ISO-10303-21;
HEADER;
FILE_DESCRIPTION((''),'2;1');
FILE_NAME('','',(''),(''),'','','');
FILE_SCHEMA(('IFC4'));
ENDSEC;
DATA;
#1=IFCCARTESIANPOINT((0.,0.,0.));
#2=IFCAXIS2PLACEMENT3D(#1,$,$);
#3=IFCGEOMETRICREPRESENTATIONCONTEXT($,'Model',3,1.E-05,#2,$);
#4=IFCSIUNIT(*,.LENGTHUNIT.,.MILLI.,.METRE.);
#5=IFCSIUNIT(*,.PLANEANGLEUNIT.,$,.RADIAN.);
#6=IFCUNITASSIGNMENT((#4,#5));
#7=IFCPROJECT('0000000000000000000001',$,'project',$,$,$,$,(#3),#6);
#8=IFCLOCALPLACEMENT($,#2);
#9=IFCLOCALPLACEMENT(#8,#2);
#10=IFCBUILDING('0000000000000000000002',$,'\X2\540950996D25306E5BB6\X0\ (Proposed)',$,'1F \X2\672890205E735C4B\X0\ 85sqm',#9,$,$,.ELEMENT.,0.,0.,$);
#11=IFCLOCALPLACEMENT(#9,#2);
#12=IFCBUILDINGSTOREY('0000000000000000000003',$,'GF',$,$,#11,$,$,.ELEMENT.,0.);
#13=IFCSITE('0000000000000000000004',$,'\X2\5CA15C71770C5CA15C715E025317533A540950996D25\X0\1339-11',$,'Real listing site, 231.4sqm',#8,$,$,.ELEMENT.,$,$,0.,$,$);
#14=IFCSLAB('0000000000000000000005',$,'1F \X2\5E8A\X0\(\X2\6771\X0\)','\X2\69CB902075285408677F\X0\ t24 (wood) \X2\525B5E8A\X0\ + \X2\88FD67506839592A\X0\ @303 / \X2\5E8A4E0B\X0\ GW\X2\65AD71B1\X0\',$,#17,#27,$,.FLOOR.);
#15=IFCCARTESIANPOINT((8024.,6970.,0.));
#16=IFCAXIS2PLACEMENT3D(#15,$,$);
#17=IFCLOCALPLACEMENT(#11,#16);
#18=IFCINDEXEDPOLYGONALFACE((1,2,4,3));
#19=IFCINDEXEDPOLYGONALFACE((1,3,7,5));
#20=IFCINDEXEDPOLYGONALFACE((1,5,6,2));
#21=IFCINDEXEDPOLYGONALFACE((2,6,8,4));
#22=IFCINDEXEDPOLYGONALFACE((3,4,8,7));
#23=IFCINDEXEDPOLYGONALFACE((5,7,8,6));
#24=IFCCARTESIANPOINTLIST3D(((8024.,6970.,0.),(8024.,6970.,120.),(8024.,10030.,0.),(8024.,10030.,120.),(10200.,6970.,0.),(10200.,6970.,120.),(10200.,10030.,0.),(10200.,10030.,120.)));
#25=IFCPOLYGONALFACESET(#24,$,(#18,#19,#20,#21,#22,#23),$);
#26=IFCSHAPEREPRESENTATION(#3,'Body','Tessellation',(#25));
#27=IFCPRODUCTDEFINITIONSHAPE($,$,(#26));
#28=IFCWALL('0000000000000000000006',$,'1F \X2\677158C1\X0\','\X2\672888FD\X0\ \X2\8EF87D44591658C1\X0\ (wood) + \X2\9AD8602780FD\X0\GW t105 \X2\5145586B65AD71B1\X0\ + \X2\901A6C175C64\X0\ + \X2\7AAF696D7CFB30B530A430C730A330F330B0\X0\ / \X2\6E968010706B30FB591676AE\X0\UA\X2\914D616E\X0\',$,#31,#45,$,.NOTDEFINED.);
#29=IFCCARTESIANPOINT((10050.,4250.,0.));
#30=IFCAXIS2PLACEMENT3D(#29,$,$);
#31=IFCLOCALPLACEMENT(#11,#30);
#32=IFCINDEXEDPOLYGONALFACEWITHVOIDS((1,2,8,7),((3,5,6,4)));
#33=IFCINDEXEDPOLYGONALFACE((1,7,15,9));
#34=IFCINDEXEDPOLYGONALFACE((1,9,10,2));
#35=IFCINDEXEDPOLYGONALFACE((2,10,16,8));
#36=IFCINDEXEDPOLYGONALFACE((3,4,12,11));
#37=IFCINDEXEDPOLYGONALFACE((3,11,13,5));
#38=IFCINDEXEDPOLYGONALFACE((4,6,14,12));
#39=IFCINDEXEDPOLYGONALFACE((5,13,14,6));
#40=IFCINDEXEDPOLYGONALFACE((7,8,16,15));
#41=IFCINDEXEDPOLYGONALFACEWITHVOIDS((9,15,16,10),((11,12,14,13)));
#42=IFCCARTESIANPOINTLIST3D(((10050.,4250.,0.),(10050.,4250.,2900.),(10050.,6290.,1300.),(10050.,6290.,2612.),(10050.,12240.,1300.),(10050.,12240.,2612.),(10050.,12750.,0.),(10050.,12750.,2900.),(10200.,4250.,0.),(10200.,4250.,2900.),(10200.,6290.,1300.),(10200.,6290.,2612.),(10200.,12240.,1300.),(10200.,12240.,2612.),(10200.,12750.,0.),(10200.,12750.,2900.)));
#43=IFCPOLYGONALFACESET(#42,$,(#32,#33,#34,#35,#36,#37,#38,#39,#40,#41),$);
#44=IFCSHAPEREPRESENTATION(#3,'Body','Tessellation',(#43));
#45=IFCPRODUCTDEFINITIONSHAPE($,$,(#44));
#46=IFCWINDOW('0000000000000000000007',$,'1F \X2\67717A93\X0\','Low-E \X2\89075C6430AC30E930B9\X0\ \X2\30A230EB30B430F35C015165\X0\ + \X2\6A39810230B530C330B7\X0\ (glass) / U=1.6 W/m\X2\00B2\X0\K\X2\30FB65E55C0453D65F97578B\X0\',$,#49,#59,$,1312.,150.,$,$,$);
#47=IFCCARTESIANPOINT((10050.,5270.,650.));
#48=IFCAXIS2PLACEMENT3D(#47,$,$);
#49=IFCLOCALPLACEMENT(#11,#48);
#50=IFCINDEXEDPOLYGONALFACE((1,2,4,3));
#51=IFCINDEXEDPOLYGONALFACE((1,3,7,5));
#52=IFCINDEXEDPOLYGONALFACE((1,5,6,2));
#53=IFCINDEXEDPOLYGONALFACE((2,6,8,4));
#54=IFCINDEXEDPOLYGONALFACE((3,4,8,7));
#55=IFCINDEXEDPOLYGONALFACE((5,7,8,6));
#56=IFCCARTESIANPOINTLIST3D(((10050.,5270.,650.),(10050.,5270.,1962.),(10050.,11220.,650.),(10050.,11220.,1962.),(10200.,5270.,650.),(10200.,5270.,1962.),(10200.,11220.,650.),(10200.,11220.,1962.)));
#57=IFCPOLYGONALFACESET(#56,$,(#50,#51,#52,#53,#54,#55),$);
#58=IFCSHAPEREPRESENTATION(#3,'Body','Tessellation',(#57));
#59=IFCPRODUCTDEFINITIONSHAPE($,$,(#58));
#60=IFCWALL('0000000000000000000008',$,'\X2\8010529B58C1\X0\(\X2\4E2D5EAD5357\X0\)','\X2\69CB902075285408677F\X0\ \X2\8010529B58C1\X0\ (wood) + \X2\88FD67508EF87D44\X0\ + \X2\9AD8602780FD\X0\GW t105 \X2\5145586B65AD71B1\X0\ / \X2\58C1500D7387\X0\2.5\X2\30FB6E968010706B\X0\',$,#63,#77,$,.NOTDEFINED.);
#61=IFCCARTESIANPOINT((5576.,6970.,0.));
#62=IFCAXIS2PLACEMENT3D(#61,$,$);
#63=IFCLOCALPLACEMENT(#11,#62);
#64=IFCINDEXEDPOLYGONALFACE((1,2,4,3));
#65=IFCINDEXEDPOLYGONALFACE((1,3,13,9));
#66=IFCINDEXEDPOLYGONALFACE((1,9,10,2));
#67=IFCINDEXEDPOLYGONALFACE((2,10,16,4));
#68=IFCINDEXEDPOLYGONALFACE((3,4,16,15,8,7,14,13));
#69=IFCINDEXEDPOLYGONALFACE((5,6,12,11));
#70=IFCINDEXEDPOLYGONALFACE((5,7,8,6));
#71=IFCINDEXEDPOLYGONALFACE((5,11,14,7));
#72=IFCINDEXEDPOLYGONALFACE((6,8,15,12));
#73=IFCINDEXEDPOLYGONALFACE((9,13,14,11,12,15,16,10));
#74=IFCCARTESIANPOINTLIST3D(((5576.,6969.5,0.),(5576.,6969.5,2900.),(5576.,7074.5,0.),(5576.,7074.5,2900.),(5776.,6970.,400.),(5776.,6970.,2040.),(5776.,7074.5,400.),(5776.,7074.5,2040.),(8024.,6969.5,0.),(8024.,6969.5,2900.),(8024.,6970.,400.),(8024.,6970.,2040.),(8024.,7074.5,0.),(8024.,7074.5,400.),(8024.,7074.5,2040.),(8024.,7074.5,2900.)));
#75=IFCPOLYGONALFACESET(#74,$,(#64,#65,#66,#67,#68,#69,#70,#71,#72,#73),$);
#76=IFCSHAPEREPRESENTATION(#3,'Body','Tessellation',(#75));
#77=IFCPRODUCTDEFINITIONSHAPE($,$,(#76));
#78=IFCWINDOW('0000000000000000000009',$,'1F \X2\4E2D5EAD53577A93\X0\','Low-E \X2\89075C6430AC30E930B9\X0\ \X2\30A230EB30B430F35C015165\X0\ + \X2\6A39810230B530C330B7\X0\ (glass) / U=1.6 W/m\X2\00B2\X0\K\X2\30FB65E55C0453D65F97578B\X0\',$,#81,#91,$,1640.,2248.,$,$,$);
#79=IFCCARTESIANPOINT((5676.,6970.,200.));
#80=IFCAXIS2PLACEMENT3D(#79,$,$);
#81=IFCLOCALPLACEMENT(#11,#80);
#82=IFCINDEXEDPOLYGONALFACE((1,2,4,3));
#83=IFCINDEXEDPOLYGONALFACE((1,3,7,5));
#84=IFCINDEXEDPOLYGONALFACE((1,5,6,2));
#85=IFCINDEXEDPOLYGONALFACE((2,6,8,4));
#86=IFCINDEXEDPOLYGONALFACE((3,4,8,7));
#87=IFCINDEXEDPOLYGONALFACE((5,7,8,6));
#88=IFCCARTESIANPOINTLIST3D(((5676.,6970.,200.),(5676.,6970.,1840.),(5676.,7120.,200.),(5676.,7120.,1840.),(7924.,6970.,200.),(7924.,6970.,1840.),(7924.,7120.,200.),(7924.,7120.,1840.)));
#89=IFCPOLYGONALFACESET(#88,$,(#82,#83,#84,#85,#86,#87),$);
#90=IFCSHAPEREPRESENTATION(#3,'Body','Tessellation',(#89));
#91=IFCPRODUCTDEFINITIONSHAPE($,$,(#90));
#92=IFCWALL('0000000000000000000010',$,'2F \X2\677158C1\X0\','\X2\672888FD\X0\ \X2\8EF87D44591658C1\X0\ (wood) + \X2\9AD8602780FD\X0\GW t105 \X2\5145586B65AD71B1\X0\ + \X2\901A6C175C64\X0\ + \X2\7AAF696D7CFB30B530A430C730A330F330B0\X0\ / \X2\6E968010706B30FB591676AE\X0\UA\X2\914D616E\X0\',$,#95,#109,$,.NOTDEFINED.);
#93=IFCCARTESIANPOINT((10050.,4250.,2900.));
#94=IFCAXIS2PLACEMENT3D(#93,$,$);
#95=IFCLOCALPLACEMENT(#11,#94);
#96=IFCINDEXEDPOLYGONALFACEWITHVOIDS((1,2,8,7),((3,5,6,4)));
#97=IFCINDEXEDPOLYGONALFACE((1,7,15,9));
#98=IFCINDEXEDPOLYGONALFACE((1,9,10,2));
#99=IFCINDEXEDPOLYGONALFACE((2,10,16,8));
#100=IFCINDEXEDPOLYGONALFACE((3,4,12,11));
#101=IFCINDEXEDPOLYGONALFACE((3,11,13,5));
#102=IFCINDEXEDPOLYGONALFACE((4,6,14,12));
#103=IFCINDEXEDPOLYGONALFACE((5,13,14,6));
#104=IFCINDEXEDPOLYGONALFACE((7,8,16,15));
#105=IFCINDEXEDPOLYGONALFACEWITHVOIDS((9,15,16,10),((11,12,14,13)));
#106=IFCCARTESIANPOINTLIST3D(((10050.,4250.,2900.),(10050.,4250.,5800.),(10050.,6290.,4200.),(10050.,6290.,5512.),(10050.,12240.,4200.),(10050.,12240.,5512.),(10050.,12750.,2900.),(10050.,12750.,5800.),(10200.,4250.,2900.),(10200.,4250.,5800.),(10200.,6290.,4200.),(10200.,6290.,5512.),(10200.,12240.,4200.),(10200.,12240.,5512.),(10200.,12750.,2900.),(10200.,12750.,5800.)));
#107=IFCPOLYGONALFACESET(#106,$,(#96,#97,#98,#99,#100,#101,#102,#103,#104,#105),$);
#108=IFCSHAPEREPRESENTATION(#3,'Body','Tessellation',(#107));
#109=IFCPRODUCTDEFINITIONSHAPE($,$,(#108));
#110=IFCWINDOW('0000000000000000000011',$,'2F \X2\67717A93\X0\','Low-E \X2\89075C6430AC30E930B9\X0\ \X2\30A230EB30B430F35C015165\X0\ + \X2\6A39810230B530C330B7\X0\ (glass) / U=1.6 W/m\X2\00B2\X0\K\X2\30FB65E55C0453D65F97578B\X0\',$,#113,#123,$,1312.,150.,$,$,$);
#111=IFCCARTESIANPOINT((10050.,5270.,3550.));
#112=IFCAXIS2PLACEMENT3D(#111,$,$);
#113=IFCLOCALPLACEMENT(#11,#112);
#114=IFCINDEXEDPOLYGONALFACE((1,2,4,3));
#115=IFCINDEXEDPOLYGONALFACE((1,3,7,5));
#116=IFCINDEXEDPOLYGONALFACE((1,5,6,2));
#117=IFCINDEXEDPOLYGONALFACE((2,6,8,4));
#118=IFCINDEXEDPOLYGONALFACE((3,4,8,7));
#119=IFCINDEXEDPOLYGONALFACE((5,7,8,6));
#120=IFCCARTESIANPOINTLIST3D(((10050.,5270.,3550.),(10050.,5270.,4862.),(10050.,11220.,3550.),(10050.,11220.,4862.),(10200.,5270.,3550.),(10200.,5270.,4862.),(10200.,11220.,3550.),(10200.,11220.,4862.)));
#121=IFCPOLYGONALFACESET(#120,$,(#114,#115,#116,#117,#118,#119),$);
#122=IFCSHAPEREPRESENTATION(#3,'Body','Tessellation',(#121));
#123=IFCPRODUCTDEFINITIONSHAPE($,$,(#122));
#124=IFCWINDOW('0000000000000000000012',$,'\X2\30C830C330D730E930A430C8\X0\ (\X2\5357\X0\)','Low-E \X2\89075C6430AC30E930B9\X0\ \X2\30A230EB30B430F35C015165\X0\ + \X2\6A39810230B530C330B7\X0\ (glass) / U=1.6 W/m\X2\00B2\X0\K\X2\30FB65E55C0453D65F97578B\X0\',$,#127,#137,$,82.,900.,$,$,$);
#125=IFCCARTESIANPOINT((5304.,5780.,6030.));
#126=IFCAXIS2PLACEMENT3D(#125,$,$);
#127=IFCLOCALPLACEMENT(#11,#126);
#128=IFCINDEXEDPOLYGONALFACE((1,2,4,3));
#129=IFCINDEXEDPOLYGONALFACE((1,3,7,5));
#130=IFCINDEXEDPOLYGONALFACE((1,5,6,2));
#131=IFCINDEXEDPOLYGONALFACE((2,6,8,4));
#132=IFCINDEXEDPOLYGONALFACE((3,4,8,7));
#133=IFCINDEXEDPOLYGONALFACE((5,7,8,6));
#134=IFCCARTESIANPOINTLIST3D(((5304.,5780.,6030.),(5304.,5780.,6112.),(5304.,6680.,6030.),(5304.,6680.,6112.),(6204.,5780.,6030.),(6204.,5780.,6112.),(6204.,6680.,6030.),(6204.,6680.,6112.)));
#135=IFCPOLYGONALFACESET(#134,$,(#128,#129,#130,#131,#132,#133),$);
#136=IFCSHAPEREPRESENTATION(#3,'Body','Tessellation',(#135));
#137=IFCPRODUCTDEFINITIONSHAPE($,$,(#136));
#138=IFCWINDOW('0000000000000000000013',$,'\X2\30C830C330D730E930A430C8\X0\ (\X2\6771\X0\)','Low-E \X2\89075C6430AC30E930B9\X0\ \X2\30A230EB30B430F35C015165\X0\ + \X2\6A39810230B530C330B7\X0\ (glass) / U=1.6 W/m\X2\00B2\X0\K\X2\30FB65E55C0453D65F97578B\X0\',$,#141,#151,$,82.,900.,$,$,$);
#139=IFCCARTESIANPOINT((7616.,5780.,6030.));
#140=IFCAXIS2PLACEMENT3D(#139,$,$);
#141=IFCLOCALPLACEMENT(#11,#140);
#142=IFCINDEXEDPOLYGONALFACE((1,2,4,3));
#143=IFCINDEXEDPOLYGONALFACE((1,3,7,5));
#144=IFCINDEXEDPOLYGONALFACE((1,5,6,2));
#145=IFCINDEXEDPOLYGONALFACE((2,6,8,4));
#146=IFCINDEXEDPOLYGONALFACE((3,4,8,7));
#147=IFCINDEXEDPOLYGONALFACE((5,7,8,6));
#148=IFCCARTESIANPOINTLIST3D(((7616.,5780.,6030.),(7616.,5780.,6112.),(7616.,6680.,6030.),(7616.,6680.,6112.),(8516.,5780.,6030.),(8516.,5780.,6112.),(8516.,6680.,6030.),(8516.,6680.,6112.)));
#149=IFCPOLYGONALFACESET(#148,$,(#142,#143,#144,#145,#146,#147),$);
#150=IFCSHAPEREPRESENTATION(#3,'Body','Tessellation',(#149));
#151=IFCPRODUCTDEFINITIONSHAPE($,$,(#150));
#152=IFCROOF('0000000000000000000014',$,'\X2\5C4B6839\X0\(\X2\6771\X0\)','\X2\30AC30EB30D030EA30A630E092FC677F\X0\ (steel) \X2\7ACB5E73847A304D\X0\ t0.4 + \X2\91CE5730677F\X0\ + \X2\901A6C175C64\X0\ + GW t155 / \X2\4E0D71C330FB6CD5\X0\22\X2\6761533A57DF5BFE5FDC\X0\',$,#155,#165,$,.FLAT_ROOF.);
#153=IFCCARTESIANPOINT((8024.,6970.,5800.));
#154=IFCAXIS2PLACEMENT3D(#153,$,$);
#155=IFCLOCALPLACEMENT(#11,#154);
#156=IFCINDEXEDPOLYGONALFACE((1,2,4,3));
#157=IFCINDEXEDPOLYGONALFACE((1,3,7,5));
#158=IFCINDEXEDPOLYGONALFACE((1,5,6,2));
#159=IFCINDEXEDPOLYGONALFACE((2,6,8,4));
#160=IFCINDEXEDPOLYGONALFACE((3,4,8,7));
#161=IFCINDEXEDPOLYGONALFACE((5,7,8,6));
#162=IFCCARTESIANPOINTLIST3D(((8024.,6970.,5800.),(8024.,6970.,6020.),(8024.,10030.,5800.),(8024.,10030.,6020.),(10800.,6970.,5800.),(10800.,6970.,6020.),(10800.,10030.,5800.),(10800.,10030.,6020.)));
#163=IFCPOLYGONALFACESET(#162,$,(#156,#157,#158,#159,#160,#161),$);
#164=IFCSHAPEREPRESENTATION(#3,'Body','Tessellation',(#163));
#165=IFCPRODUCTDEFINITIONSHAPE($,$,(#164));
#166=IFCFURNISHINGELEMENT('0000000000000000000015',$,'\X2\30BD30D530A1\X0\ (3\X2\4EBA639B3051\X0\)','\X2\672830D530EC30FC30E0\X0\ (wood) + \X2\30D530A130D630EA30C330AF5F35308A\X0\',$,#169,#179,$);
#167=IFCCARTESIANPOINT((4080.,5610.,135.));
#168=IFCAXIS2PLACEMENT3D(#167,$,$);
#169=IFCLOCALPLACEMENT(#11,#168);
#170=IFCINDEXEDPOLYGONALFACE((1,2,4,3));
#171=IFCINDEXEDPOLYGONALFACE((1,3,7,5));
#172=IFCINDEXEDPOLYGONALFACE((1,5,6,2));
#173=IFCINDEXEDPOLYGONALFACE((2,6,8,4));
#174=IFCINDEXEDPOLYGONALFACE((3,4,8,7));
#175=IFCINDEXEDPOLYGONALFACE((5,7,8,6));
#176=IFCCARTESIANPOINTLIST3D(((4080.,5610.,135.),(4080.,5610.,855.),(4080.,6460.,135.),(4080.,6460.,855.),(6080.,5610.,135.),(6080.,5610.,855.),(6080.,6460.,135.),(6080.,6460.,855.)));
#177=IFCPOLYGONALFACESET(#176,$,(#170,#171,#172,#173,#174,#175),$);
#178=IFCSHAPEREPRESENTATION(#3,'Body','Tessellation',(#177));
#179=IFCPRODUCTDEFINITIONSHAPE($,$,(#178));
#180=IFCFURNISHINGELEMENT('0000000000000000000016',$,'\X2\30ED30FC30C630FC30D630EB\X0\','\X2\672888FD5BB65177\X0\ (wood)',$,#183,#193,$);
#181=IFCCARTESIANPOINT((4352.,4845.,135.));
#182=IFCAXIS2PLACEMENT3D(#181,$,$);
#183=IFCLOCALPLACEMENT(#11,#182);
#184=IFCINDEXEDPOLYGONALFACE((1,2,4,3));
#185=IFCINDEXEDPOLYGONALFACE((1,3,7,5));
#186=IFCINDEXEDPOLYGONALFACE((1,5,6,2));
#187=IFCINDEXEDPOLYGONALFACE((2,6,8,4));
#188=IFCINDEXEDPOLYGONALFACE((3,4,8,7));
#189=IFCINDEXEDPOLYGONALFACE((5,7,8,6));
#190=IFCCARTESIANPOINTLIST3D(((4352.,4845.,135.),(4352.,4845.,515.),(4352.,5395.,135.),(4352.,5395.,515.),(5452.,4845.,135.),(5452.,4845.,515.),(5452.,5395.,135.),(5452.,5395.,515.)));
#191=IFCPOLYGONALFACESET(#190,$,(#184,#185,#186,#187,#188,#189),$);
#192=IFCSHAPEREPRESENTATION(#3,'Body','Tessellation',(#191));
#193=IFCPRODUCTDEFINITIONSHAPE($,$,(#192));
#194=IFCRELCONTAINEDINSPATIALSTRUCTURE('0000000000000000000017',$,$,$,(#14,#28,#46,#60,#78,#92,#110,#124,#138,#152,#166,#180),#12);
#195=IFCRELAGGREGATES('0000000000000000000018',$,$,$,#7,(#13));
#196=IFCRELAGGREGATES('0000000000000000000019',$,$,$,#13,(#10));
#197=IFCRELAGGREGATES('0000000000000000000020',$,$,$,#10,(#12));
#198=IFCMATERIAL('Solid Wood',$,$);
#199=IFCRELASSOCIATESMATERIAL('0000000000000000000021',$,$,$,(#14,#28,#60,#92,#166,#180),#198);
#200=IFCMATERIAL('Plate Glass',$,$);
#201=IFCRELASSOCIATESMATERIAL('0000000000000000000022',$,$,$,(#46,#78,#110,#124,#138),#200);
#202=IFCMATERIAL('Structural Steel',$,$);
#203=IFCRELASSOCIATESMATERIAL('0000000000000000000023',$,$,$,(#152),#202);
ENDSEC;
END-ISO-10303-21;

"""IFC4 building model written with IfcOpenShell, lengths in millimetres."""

from ifc_helpers import new_model, si_unit, frame, frame_2d, origin, place, context, project, spatial, rectangle, extrude, material, element, fill, save


model = new_model("IFC4")

# Units and contexts
model_context = context("Model", 3, precision=1e-05, world=origin())
ifc_project = project(units=[si_unit("LENGTHUNIT", "METRE", prefix="MILLI"), si_unit("PLANEANGLEUNIT", "RADIAN")], contexts=[model_context])

# Site, building, storey
site_placement = place(None, origin())
site = spatial("IfcSite", under=ifc_project, at=site_placement, Name="岡山県岡山市北区吉備津1339-11", ObjectType="Real listing site, 231.4sqm", CompositionType="ELEMENT", RefElevation=0.0)
building_placement = place(site_placement, origin())
building = spatial("IfcBuilding", under=site, at=building_placement, Name="吉備津の家 (Proposed)", ObjectType="1F 木造平屋 85sqm", CompositionType="ELEMENT", ElevationOfRefHeight=0.0, ElevationOfTerrain=0.0)
storey_placement = place(building_placement, origin())
storey = spatial("IfcBuildingStorey", under=building, at=storey_placement, Name="GF", CompositionType="ELEMENT", Elevation=0.0)

# Slab
ifc_material_1 = material(Name="Solid Wood")
slab_placement = place(storey_placement, frame((8024.0, 6970.0, 0.0)))
element("IfcSlab", 1, at=slab_placement, inside=storey, material=ifc_material_1, Name="1F 床(東)", Description="構造用合板 t24 (wood) 剛床 + 製材根太 @303 / 床下 GW断熱", PredefinedType="FLOOR", context=model_context, shape_type="SweptSolid", body=[
    extrude(rectangle(XDim=2176.0, YDim=3060.0, at=frame_2d((1088.0, 1530.0))), frame((8024.0, 6970.0, 0.0)), (0.0, 0.0, 1.0), 120.0),
])

# Walls, openings, windows
wall_1_placement = place(storey_placement, frame((10050.0, 4250.0, 0.0)))
wall_1 = element("IfcWall", 2, at=wall_1_placement, inside=storey, material=ifc_material_1, Name="1F 東壁", Description="木製 軸組外壁 (wood) + 高性能GW t105 充填断熱 + 通気層 + 窯業系サイディング / 準耐火・外皮UA配慮", PredefinedType="NOTDEFINED", context=model_context, shape_type="SweptSolid", body=[
    extrude(rectangle(XDim=150.0, YDim=8500.0, at=frame_2d((75.0, 4250.0))), frame((10050.0, 4250.0, 0.0)), (0.0, 0.0, 1.0), 2900.0),
])
opening_1_placement = place(storey_placement, frame((10050.0, 5270.0, 650.0)))
opening_1 = element("IfcOpeningElement", 3, at=opening_1_placement, cuts=wall_1, PredefinedType="NOTDEFINED", context=model_context, shape_type="SweptSolid", body=[
    extrude(rectangle(XDim=150.0, YDim=5950.0, at=frame_2d((75.0, 2975.0))), frame((10050.0, 5270.0, 650.0)), (0.0, 0.0, 1.0), 1312.0),
])
ifc_material_2 = material(Name="Plate Glass")
window_1_placement = place(storey_placement, frame((10050.0, 5270.0, 650.0)))
window_1 = element("IfcWindow", 4, at=window_1_placement, inside=storey, material=ifc_material_2, Name="1F 東窓", Description="Low-E 複層ガラス アルゴン封入 + 樹脂サッシ (glass) / U=1.6 W/m²K・日射取得型", OverallHeight=1312.0, OverallWidth=150.0, context=model_context, shape_type="SweptSolid", body=[
    extrude(rectangle(XDim=150.0, YDim=5950.0, at=frame_2d((75.0, 2975.0))), frame((10050.0, 5270.0, 650.0)), (0.0, 0.0, 1.0), 1312.0),
])
fill(opening_1, window_1)
wall_2_placement = place(storey_placement, frame((5576.0, 6970.0, 0.0)))
wall_2 = element("IfcWall", 5, at=wall_2_placement, inside=storey, material=ifc_material_1, Name="耐力壁(中庭南)", Description="構造用合板 耐力壁 (wood) + 製材軸組 + 高性能GW t105 充填断熱 / 壁倍率2.5・準耐火", PredefinedType="NOTDEFINED", context=model_context, shape_type="SweptSolid", body=[
    extrude(rectangle(XDim=2448.0, YDim=105.0, at=frame_2d((1224.0, 52.0))), frame((5576.0, 6970.0, 0.0)), (0.0, 0.0, 1.0), 2900.0),
])
opening_2_placement = place(storey_placement, frame((5676.0, 6970.0, 200.0)))
opening_2 = element("IfcOpeningElement", 6, at=opening_2_placement, cuts=wall_2, PredefinedType="NOTDEFINED", context=model_context, shape_type="SweptSolid", body=[
    extrude(rectangle(XDim=2248.0, YDim=150.0, at=frame_2d((1124.0, 75.0))), frame((5676.0, 6970.0, 200.0)), (0.0, 0.0, 1.0), 1640.0),
])
window_2_placement = place(storey_placement, frame((5676.0, 6970.0, 200.0)))
window_2 = element("IfcWindow", 7, at=window_2_placement, inside=storey, material=ifc_material_2, Name="1F 中庭南窓", Description="Low-E 複層ガラス アルゴン封入 + 樹脂サッシ (glass) / U=1.6 W/m²K・日射取得型", OverallHeight=1640.0, OverallWidth=2248.0, context=model_context, shape_type="SweptSolid", body=[
    extrude(rectangle(XDim=2248.0, YDim=150.0, at=frame_2d((1124.0, 75.0))), frame((5676.0, 6970.0, 200.0)), (0.0, 0.0, 1.0), 1640.0),
])
fill(opening_2, window_2)

# Wall, opening, window
wall_3_placement = place(storey_placement, frame((10050.0, 4250.0, 2900.0)))
wall_3 = element("IfcWall", 8, at=wall_3_placement, inside=storey, material=ifc_material_1, Name="2F 東壁", Description="木製 軸組外壁 (wood) + 高性能GW t105 充填断熱 + 通気層 + 窯業系サイディング / 準耐火・外皮UA配慮", PredefinedType="NOTDEFINED", context=model_context, shape_type="SweptSolid", body=[
    extrude(rectangle(XDim=150.0, YDim=8500.0, at=frame_2d((75.0, 4250.0))), frame((10050.0, 4250.0, 2900.0)), (0.0, 0.0, 1.0), 2900.0),
])
opening_3_placement = place(storey_placement, frame((10050.0, 5270.0, 3550.0)))
opening_3 = element("IfcOpeningElement", 9, at=opening_3_placement, cuts=wall_3, PredefinedType="NOTDEFINED", context=model_context, shape_type="SweptSolid", body=[
    extrude(rectangle(XDim=150.0, YDim=5950.0, at=frame_2d((75.0, 2975.0))), frame((10050.0, 5270.0, 3550.0)), (0.0, 0.0, 1.0), 1312.0),
])
window_3_placement = place(storey_placement, frame((10050.0, 5270.0, 3550.0)))
window_3 = element("IfcWindow", 10, at=window_3_placement, inside=storey, material=ifc_material_2, Name="2F 東窓", Description="Low-E 複層ガラス アルゴン封入 + 樹脂サッシ (glass) / U=1.6 W/m²K・日射取得型", OverallHeight=1312.0, OverallWidth=150.0, context=model_context, shape_type="SweptSolid", body=[
    extrude(rectangle(XDim=150.0, YDim=5950.0, at=frame_2d((75.0, 2975.0))), frame((10050.0, 5270.0, 3550.0)), (0.0, 0.0, 1.0), 1312.0),
])
fill(opening_3, window_3)

# Windows
window_4_placement = place(storey_placement, frame((5304.0, 5780.0, 6030.0)))
element("IfcWindow", 11, at=window_4_placement, inside=storey, material=ifc_material_2, Name="トップライト (南)", Description="Low-E 複層ガラス アルゴン封入 + 樹脂サッシ (glass) / U=1.6 W/m²K・日射取得型", OverallHeight=82.0, OverallWidth=900.0, context=model_context, shape_type="SweptSolid", body=[
    extrude(rectangle(XDim=900.0, YDim=900.0, at=frame_2d((450.0, 450.0))), frame((5304.0, 5780.0, 6030.0)), (0.0, 0.0, 1.0), 82.0),
])
window_5_placement = place(storey_placement, frame((7616.0, 5780.0, 6030.0)))
element("IfcWindow", 12, at=window_5_placement, inside=storey, material=ifc_material_2, Name="トップライト (東)", Description="Low-E 複層ガラス アルゴン封入 + 樹脂サッシ (glass) / U=1.6 W/m²K・日射取得型", OverallHeight=82.0, OverallWidth=900.0, context=model_context, shape_type="SweptSolid", body=[
    extrude(rectangle(XDim=900.0, YDim=900.0, at=frame_2d((450.0, 450.0))), frame((7616.0, 5780.0, 6030.0)), (0.0, 0.0, 1.0), 82.0),
])

# Roof
ifc_material_3 = material(Name="Structural Steel")
roof_placement = place(storey_placement, frame((8024.0, 6970.0, 5800.0)))
element("IfcRoof", 13, at=roof_placement, inside=storey, material=ifc_material_3, Name="屋根(東)", Description="ガルバリウム鋼板 (steel) 立平葺き t0.4 + 野地板 + 通気層 + GW t155 / 不燃・法22条区域対応", PredefinedType="FLAT_ROOF", context=model_context, shape_type="SweptSolid", body=[
    extrude(rectangle(XDim=2776.0, YDim=3060.0, at=frame_2d((1388.0, 1530.0))), frame((8024.0, 6970.0, 5800.0)), (0.0, 0.0, 1.0), 220.0),
])

# Furnishing elements
furnishing_1_placement = place(storey_placement, frame((4080.0, 5610.0, 135.0)))
element("IfcFurnishingElement", 14, at=furnishing_1_placement, inside=storey, material=ifc_material_1, Name="ソファ (3人掛け)", Description="木フレーム (wood) + ファブリック張り", context=model_context, shape_type="SweptSolid", body=[
    extrude(rectangle(XDim=2000.0, YDim=850.0, at=frame_2d((1000.0, 425.0))), frame((4080.0, 5610.0, 135.0)), (0.0, 0.0, 1.0), 720.0),
])
furnishing_2_placement = place(storey_placement, frame((4352.0, 4845.0, 135.0)))
element("IfcFurnishingElement", 15, at=furnishing_2_placement, inside=storey, material=ifc_material_1, Name="ローテーブル", Description="木製家具 (wood)", context=model_context, shape_type="SweptSolid", body=[
    extrude(rectangle(XDim=1100.0, YDim=550.0, at=frame_2d((550.0, 275.0))), frame((4352.0, 4845.0, 135.0)), (0.0, 0.0, 1.0), 380.0),
])

save(model, "model.ifc")
